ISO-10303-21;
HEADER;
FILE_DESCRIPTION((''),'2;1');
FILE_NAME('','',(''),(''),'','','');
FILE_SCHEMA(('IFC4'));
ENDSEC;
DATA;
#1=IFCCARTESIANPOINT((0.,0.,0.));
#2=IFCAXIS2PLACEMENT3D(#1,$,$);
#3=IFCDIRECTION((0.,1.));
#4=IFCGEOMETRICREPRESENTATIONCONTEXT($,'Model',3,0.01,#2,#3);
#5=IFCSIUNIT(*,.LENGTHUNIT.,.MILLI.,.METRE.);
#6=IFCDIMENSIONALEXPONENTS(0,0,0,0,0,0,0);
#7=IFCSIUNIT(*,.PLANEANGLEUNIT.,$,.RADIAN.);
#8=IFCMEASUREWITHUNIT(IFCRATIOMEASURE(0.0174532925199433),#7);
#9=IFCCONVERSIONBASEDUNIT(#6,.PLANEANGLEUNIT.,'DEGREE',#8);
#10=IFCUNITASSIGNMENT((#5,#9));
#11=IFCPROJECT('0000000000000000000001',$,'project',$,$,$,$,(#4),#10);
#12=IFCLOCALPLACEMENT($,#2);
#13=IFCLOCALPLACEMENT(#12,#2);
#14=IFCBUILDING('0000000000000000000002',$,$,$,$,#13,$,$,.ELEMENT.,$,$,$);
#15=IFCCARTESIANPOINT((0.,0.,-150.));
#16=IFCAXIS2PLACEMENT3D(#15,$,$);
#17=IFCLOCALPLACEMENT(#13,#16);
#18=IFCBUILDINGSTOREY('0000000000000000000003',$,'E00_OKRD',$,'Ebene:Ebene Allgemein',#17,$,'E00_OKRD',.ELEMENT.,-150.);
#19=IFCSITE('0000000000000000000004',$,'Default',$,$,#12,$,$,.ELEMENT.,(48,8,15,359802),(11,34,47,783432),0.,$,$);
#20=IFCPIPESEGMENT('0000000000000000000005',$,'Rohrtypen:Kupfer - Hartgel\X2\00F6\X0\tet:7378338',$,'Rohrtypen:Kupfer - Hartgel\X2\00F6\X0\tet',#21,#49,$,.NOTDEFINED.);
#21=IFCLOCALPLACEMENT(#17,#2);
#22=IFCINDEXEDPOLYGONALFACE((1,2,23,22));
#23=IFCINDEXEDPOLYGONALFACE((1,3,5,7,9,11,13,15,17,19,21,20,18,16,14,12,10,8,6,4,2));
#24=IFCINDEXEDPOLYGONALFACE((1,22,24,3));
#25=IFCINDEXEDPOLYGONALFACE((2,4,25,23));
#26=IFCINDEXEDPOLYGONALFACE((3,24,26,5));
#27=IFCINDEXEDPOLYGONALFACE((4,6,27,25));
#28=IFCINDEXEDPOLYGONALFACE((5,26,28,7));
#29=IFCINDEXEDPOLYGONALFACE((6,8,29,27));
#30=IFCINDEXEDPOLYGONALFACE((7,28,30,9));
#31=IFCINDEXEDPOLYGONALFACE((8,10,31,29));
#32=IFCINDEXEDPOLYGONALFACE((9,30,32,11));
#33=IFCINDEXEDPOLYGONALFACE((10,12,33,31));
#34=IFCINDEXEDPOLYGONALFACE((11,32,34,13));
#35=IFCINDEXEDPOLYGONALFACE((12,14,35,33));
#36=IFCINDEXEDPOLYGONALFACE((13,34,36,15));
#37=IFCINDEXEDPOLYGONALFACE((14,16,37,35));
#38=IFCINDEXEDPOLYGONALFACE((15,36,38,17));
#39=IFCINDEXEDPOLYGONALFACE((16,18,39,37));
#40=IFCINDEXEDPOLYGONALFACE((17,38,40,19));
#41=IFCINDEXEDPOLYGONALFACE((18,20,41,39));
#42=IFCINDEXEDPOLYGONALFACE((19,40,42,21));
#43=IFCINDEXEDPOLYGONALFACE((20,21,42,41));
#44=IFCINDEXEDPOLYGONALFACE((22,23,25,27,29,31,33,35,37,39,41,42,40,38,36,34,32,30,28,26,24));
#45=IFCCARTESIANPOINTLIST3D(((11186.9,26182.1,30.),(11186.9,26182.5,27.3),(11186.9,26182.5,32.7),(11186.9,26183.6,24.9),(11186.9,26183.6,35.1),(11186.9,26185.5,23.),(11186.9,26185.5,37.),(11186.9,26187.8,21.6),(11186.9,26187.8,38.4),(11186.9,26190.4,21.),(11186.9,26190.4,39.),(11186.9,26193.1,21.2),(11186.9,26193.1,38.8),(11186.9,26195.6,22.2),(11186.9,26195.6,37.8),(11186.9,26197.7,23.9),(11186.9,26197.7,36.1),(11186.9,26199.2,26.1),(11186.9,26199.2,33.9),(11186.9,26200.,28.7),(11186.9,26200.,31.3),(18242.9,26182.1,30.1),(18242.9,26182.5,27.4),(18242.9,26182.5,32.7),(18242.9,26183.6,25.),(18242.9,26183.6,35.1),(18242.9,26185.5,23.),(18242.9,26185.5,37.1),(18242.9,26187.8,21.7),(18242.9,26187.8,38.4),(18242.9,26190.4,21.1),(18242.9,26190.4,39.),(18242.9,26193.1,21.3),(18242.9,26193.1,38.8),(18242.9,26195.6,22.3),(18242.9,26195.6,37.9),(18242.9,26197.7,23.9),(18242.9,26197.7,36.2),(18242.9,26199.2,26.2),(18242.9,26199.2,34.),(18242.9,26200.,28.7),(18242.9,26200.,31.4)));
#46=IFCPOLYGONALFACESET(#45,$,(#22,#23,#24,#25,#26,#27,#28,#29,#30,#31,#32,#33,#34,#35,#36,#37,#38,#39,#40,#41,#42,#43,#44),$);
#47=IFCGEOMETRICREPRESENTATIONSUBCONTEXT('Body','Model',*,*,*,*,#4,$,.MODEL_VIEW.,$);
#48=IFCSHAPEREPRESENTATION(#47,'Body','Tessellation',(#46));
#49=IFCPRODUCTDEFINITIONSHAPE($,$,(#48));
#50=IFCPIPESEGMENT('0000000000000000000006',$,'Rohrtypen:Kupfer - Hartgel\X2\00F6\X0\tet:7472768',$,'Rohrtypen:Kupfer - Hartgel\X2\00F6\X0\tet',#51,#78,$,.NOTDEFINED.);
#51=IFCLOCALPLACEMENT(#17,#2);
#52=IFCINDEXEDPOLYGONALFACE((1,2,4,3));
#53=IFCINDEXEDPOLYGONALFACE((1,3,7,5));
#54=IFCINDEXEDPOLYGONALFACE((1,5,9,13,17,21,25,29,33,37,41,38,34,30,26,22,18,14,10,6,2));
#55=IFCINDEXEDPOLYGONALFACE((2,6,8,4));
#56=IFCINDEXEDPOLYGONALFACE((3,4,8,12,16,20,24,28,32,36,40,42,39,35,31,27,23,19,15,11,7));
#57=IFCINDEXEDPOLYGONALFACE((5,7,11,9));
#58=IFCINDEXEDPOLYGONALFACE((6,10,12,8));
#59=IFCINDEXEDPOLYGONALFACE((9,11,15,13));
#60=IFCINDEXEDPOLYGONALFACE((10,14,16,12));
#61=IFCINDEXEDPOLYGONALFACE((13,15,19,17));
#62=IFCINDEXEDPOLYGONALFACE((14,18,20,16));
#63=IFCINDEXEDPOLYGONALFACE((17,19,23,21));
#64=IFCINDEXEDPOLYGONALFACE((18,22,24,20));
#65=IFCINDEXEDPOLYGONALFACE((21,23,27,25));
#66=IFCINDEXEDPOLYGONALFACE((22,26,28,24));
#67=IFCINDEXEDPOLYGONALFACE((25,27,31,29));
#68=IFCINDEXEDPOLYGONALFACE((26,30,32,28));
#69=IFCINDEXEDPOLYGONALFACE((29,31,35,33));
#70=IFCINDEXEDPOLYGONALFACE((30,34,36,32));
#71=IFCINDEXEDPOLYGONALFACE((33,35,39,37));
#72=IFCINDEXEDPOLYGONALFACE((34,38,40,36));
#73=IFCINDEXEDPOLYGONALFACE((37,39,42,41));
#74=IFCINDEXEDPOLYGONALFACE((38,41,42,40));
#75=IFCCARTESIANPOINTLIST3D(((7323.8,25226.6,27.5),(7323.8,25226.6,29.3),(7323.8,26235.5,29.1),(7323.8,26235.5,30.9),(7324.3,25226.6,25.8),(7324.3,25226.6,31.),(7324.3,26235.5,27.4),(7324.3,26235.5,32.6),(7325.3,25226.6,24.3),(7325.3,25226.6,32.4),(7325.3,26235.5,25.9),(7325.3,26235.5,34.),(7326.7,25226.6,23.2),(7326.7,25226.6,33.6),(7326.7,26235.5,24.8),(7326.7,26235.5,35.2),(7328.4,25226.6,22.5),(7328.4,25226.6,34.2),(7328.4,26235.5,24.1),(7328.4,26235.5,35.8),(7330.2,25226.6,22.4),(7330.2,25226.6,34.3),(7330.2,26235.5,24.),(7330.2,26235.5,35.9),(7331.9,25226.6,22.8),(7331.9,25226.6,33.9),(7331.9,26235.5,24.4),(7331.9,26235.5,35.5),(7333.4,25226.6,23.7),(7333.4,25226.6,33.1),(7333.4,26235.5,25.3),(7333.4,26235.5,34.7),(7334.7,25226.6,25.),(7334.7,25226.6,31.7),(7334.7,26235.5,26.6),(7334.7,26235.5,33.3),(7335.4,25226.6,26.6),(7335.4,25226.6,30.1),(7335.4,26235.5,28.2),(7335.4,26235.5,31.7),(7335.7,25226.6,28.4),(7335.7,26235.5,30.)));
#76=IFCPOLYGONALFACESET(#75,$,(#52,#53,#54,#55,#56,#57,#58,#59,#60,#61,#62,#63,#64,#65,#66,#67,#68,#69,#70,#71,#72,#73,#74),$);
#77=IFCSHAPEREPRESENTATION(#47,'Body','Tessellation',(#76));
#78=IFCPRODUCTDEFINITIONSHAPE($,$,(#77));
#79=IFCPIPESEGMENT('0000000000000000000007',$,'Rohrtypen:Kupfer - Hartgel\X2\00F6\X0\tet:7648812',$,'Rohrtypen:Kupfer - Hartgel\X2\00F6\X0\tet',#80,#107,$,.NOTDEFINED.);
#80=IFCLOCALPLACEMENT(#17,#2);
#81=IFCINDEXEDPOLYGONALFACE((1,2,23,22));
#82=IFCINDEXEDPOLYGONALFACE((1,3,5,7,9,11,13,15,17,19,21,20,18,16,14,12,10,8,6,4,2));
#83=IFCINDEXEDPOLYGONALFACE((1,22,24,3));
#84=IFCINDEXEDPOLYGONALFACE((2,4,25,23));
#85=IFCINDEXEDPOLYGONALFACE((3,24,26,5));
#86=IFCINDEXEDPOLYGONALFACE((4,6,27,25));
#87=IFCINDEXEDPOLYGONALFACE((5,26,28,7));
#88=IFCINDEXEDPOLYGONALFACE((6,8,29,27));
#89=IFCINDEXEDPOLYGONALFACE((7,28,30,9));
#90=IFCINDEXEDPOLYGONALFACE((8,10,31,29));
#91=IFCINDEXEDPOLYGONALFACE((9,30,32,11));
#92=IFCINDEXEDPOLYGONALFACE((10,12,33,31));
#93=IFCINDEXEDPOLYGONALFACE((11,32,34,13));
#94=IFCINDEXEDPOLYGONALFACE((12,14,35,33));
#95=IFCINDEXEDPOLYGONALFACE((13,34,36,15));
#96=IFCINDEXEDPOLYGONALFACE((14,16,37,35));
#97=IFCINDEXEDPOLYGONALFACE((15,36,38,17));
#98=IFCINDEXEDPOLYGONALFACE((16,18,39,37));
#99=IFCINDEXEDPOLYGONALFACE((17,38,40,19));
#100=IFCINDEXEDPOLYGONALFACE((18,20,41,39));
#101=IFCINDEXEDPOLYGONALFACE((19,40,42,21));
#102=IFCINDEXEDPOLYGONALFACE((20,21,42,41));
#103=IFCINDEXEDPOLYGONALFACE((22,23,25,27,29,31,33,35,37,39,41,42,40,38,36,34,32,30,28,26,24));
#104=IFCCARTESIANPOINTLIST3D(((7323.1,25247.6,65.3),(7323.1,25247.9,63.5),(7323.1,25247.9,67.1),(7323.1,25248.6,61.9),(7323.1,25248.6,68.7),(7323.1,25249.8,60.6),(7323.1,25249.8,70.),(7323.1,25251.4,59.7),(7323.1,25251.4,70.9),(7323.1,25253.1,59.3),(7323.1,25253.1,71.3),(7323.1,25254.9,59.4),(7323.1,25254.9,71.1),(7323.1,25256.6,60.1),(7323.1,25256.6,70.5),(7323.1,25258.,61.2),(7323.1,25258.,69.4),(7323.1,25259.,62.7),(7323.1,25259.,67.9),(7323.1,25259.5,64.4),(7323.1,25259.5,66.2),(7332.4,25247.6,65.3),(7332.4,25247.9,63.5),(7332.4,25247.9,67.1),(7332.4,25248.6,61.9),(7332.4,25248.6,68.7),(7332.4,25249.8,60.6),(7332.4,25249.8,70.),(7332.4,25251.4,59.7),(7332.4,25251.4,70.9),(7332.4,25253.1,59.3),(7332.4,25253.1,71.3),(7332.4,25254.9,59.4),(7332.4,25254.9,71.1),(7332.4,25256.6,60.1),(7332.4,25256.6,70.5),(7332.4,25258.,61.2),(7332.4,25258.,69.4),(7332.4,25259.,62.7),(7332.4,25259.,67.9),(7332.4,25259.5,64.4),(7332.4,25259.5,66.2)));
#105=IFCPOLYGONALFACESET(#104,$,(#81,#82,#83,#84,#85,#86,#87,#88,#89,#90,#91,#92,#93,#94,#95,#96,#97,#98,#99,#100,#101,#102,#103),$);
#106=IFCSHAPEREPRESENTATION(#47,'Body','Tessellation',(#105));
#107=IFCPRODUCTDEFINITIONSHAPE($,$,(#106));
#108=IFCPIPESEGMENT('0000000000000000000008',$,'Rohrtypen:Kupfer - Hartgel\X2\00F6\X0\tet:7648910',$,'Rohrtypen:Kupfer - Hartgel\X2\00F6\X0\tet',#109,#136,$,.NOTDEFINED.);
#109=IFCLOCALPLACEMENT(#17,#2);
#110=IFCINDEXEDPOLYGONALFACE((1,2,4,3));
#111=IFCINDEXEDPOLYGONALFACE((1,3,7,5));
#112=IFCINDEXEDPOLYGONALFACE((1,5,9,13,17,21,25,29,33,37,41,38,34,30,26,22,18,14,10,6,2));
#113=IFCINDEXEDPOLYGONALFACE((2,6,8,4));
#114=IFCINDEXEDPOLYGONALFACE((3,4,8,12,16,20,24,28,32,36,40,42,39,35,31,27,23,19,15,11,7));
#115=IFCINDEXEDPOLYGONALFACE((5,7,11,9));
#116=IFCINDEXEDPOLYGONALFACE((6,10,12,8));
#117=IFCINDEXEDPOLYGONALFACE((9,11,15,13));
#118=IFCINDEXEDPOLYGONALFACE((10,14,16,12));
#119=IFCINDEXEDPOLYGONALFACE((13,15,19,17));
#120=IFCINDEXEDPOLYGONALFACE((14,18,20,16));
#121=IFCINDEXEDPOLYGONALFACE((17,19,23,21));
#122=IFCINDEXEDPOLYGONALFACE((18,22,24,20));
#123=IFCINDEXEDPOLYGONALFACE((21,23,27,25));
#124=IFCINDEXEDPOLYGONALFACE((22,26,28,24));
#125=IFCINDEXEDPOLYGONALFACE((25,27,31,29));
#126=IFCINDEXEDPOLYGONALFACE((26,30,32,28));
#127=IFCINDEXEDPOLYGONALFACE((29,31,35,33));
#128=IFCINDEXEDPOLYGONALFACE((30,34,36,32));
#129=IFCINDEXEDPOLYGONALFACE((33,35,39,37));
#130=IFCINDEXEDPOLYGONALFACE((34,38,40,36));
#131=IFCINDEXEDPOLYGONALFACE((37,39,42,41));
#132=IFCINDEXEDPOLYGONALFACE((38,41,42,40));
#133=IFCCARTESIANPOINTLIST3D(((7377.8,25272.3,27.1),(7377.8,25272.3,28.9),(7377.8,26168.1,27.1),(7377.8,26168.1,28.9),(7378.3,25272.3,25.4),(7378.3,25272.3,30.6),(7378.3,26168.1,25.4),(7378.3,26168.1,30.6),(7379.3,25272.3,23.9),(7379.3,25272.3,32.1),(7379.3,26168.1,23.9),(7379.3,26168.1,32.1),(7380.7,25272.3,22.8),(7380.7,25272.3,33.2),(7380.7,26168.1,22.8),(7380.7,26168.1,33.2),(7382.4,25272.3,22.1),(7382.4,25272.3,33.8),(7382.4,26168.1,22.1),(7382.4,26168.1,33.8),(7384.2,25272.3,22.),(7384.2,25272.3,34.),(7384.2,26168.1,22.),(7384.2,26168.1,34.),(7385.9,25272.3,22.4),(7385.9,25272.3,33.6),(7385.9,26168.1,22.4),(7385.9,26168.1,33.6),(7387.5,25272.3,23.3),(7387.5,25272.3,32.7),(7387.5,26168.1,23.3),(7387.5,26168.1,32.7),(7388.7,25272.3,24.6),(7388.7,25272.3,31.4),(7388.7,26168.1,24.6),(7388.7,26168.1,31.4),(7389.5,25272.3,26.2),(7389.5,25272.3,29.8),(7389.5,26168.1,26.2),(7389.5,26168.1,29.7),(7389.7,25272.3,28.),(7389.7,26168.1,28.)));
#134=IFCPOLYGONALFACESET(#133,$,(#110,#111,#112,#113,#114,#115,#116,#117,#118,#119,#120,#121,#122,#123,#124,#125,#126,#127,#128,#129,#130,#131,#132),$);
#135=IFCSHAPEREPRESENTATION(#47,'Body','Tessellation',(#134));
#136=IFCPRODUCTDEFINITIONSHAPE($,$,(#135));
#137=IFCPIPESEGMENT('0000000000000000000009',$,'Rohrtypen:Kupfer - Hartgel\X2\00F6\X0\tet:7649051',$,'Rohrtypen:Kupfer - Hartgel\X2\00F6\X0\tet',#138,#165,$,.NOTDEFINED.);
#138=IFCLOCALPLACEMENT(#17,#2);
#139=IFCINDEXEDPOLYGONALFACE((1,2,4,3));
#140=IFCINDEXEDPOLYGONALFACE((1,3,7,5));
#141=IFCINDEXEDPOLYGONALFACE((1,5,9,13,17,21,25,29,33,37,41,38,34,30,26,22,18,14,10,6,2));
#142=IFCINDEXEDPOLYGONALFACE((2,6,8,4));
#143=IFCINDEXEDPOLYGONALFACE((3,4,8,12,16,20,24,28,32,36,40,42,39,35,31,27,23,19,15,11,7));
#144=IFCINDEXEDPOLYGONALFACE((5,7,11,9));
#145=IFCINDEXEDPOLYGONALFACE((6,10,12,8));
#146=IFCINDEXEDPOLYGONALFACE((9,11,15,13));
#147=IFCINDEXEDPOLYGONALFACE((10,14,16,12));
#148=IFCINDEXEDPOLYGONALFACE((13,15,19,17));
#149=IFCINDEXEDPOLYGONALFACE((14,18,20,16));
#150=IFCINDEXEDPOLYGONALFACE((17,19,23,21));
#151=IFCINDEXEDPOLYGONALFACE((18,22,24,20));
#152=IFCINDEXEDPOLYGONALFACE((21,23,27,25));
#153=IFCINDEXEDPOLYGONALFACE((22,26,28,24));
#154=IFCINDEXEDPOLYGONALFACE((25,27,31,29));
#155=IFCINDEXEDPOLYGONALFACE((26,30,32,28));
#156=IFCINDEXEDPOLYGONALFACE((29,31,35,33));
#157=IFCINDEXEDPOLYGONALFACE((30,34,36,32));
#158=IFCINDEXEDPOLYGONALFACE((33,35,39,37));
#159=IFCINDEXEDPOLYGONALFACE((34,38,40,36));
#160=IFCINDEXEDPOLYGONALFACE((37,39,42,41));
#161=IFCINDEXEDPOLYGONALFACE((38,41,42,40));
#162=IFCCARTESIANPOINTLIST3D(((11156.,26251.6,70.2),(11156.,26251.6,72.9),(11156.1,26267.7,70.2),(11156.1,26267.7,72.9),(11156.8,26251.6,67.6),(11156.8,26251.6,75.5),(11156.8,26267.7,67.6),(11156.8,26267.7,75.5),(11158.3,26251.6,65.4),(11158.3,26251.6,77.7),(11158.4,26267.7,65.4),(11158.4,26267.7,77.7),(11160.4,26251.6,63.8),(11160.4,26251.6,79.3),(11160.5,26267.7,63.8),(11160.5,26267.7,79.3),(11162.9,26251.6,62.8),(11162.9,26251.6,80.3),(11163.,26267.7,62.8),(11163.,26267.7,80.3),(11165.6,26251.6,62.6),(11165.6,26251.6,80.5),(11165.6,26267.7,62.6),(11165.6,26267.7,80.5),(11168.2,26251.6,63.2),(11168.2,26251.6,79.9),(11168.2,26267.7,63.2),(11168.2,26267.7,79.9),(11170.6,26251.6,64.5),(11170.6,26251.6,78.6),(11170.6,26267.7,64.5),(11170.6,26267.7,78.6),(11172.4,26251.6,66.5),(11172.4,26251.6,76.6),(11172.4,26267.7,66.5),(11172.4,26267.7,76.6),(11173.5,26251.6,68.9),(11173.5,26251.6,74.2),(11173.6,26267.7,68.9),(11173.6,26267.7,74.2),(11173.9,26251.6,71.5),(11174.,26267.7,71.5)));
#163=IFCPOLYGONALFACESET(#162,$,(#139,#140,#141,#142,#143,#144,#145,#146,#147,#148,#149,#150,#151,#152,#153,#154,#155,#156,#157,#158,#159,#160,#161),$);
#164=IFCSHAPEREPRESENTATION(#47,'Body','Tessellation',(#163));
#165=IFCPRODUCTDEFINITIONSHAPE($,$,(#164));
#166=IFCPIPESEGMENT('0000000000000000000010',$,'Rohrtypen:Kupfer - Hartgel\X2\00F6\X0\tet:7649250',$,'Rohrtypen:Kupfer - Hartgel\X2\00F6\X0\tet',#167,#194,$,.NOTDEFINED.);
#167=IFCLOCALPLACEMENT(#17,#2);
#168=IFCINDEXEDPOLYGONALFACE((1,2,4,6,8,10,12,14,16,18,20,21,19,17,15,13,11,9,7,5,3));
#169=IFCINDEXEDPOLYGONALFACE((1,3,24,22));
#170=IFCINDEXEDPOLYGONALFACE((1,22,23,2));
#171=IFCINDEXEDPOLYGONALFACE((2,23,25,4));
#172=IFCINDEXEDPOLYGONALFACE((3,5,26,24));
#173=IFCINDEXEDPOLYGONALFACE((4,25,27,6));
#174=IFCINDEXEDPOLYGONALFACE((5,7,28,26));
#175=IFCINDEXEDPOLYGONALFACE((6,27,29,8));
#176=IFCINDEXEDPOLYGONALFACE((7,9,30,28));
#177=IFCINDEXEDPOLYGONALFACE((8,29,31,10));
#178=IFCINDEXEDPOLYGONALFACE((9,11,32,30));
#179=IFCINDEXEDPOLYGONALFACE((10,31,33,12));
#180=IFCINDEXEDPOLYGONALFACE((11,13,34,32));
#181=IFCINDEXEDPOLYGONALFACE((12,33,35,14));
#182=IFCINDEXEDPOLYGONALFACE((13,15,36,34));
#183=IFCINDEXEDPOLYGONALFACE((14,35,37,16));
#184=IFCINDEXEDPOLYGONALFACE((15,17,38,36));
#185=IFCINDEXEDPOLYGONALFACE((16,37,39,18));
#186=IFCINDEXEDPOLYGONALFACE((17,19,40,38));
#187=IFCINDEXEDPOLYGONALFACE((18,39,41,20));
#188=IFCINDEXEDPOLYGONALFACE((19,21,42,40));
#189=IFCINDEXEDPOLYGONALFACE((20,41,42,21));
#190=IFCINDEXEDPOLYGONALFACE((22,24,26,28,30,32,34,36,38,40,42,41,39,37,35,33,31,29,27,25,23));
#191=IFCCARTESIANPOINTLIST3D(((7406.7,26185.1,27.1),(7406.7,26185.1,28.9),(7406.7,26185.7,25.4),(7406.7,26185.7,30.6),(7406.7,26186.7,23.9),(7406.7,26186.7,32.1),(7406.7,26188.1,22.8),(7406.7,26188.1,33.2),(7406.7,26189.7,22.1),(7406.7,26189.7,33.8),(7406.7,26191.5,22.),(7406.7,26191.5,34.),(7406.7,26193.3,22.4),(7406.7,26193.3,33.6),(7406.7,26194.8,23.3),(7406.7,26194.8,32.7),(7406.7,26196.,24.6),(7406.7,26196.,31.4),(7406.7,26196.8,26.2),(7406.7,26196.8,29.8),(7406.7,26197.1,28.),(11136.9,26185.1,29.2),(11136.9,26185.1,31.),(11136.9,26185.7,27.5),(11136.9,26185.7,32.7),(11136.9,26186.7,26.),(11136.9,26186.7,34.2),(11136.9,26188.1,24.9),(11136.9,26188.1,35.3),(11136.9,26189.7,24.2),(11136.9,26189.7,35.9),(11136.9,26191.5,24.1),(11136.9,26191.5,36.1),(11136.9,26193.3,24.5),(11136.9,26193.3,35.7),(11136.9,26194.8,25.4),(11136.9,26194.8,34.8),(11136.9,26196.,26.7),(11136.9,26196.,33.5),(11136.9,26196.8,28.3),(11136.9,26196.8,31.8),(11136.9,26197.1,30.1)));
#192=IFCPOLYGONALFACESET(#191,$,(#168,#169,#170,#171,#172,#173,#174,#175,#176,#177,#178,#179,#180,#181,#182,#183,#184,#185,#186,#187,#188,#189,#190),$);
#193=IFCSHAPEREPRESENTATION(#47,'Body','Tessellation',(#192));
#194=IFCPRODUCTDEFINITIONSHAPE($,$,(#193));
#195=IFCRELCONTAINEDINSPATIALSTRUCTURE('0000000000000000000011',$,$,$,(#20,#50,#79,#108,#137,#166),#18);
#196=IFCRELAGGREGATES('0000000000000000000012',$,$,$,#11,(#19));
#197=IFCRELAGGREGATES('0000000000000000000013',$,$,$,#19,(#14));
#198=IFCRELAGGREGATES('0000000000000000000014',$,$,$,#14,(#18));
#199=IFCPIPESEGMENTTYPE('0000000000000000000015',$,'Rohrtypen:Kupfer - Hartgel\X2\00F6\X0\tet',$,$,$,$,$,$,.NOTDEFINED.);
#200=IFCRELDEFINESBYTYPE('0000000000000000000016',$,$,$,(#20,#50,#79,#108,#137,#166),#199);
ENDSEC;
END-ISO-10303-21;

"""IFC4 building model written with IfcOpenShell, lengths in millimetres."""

from ifc_helpers import new_model, entity, si_unit, converted_unit, direction, frame, frame_2d, origin, origin_2d_with_axis, place, context, subcontext, project, spatial, circle, extrude, type_object, element, save


model = new_model("IFC4")

# Units and contexts
model_context = context("Model", 3, precision=0.01, world=origin(), true_north=direction((0.0, 1.0)))
body_context = subcontext(model_context, "Body", "Model", "MODEL_VIEW")
ifc_project = project(units=[si_unit("LENGTHUNIT", "METRE", prefix="MILLI"), converted_unit("PLANEANGLEUNIT", "DEGREE", entity("IfcRatioMeasure", 0.0174532925199433), si_unit("PLANEANGLEUNIT", "RADIAN"), dimensions=[0, 0, 0, 0, 0, 0, 0])], contexts=[model_context])

# Site, building, storey
site_placement = place(None, origin())
site = spatial("IfcSite", under=ifc_project, at=site_placement, Name="Default", CompositionType="ELEMENT", RefLatitude=(48, 8, 15, 359802), RefLongitude=(11, 34, 47, 783432), RefElevation=0.0)
building_placement = place(site_placement, origin())
building = spatial("IfcBuilding", under=site, at=building_placement, CompositionType="ELEMENT")
storey_placement = place(building_placement, frame((0.0, 0.0, -150.0)))
storey = spatial("IfcBuildingStorey", under=building, at=storey_placement, Name="E00_OKRD", ObjectType="Ebene:Ebene Allgemein", LongName="E00_OKRD", CompositionType="ELEMENT", Elevation=-150.0)

# Pipe segments
pipe_segment_type = type_object("IfcPipeSegmentType", Name="Rohrtypen:Kupfer - Hartgelötet", PredefinedType="NOTDEFINED")
pipe_segment_1_placement = place(storey_placement, frame((11186.9, 26180.5, 19.4)))
element("IfcPipeSegment", 1, at=pipe_segment_1_placement, inside=storey, type_object=pipe_segment_type, Name="Rohrtypen:Kupfer - Hartgelötet:7378338", ObjectType="Rohrtypen:Kupfer - Hartgelötet", PredefinedType="NOTDEFINED", context=body_context, shape_type="SweptSolid", body=[
    extrude(circle(Radius=9.0, at=frame_2d((0.0, 0.0), x_axis=(1.0, 0.0))), frame((0.0, 10.6, 10.6), z_axis=(1.0, 0.0, 0.00001), x_axis=(0.0, -1.0, 0.0)), (0.0, 0.0, 1.0), 7056.0),
])
pipe_segment_2_placement = place(storey_placement, frame((7322.1, 25226.6, 20.8)))
element("IfcPipeSegment", 2, at=pipe_segment_2_placement, inside=storey, type_object=pipe_segment_type, Name="Rohrtypen:Kupfer - Hartgelötet:7472768", ObjectType="Rohrtypen:Kupfer - Hartgelötet", PredefinedType="NOTDEFINED", context=body_context, shape_type="SweptSolid", body=[
    extrude(circle(Radius=6.0, at=origin_2d_with_axis()), frame((7.6, 0.0, 7.6), z_axis=(0.0, 0.999999, 0.001586), x_axis=(1.0, 0.0, 0.0)), (0.0, 0.0, 1.0), 1008.9),
])
pipe_segment_3_placement = place(storey_placement, frame((7323.1, 25246.0, 57.7)))
element("IfcPipeSegment", 3, at=pipe_segment_3_placement, inside=storey, type_object=pipe_segment_type, Name="Rohrtypen:Kupfer - Hartgelötet:7648812", ObjectType="Rohrtypen:Kupfer - Hartgelötet", PredefinedType="NOTDEFINED", context=body_context, shape_type="SweptSolid", body=[
    extrude(circle(Radius=6.0, at=origin_2d_with_axis()), frame((0.0, 7.6, 7.6), z_axis=(1.0, -0.000002, 0.0), x_axis=(-0.000002, -1.0, 0.0)), (0.0, 0.0, 1.0), 9.3),
])
pipe_segment_4_placement = place(storey_placement, frame((7376.1, 25272.3, 20.4)))
element("IfcPipeSegment", 4, at=pipe_segment_4_placement, inside=storey, type_object=pipe_segment_type, Name="Rohrtypen:Kupfer - Hartgelötet:7648910", ObjectType="Rohrtypen:Kupfer - Hartgelötet", PredefinedType="NOTDEFINED", context=body_context, shape_type="SweptSolid", body=[
    extrude(circle(Radius=6.0, at=origin_2d_with_axis()), frame((7.6, 0.0, 7.6), z_axis=(0.0, 1.0, -0.000009), x_axis=(1.0, 0.0, 0.0)), (0.0, 0.0, 1.0), 895.8),
])
pipe_segment_5_placement = place(storey_placement, frame((11154.3, 26251.6, 61.0)))
element("IfcPipeSegment", 5, at=pipe_segment_5_placement, inside=storey, type_object=pipe_segment_type, Name="Rohrtypen:Kupfer - Hartgelötet:7649051", ObjectType="Rohrtypen:Kupfer - Hartgelötet", PredefinedType="NOTDEFINED", context=body_context, shape_type="SweptSolid", body=[
    extrude(circle(Radius=9.0, at=frame_2d((0.0, 0.0), x_axis=(1.0, 0.0))), frame((10.6, 0.0, 10.6), z_axis=(0.000964, 1.0, 0.000194), x_axis=(1.0, -0.000964, 0.0)), (0.0, 0.0, 1.0), 16.0),
])
pipe_segment_6_placement = place(storey_placement, frame((7406.7, 26183.5, 20.4)))
element("IfcPipeSegment", 6, at=pipe_segment_6_placement, inside=storey, type_object=pipe_segment_type, Name="Rohrtypen:Kupfer - Hartgelötet:7649250", ObjectType="Rohrtypen:Kupfer - Hartgelötet", PredefinedType="NOTDEFINED", context=body_context, shape_type="SweptSolid", body=[
    extrude(circle(Radius=6.0, at=frame_2d((0.0, 0.0), x_axis=(1.0, 0.0))), frame((0.0, 7.6, 7.6), z_axis=(1.0, 0.0, 0.00056), x_axis=(0.0, 1.0, 0.0)), (0.0, 0.0, 1.0), 3730.2),
])

save(model, "model.ifc")
